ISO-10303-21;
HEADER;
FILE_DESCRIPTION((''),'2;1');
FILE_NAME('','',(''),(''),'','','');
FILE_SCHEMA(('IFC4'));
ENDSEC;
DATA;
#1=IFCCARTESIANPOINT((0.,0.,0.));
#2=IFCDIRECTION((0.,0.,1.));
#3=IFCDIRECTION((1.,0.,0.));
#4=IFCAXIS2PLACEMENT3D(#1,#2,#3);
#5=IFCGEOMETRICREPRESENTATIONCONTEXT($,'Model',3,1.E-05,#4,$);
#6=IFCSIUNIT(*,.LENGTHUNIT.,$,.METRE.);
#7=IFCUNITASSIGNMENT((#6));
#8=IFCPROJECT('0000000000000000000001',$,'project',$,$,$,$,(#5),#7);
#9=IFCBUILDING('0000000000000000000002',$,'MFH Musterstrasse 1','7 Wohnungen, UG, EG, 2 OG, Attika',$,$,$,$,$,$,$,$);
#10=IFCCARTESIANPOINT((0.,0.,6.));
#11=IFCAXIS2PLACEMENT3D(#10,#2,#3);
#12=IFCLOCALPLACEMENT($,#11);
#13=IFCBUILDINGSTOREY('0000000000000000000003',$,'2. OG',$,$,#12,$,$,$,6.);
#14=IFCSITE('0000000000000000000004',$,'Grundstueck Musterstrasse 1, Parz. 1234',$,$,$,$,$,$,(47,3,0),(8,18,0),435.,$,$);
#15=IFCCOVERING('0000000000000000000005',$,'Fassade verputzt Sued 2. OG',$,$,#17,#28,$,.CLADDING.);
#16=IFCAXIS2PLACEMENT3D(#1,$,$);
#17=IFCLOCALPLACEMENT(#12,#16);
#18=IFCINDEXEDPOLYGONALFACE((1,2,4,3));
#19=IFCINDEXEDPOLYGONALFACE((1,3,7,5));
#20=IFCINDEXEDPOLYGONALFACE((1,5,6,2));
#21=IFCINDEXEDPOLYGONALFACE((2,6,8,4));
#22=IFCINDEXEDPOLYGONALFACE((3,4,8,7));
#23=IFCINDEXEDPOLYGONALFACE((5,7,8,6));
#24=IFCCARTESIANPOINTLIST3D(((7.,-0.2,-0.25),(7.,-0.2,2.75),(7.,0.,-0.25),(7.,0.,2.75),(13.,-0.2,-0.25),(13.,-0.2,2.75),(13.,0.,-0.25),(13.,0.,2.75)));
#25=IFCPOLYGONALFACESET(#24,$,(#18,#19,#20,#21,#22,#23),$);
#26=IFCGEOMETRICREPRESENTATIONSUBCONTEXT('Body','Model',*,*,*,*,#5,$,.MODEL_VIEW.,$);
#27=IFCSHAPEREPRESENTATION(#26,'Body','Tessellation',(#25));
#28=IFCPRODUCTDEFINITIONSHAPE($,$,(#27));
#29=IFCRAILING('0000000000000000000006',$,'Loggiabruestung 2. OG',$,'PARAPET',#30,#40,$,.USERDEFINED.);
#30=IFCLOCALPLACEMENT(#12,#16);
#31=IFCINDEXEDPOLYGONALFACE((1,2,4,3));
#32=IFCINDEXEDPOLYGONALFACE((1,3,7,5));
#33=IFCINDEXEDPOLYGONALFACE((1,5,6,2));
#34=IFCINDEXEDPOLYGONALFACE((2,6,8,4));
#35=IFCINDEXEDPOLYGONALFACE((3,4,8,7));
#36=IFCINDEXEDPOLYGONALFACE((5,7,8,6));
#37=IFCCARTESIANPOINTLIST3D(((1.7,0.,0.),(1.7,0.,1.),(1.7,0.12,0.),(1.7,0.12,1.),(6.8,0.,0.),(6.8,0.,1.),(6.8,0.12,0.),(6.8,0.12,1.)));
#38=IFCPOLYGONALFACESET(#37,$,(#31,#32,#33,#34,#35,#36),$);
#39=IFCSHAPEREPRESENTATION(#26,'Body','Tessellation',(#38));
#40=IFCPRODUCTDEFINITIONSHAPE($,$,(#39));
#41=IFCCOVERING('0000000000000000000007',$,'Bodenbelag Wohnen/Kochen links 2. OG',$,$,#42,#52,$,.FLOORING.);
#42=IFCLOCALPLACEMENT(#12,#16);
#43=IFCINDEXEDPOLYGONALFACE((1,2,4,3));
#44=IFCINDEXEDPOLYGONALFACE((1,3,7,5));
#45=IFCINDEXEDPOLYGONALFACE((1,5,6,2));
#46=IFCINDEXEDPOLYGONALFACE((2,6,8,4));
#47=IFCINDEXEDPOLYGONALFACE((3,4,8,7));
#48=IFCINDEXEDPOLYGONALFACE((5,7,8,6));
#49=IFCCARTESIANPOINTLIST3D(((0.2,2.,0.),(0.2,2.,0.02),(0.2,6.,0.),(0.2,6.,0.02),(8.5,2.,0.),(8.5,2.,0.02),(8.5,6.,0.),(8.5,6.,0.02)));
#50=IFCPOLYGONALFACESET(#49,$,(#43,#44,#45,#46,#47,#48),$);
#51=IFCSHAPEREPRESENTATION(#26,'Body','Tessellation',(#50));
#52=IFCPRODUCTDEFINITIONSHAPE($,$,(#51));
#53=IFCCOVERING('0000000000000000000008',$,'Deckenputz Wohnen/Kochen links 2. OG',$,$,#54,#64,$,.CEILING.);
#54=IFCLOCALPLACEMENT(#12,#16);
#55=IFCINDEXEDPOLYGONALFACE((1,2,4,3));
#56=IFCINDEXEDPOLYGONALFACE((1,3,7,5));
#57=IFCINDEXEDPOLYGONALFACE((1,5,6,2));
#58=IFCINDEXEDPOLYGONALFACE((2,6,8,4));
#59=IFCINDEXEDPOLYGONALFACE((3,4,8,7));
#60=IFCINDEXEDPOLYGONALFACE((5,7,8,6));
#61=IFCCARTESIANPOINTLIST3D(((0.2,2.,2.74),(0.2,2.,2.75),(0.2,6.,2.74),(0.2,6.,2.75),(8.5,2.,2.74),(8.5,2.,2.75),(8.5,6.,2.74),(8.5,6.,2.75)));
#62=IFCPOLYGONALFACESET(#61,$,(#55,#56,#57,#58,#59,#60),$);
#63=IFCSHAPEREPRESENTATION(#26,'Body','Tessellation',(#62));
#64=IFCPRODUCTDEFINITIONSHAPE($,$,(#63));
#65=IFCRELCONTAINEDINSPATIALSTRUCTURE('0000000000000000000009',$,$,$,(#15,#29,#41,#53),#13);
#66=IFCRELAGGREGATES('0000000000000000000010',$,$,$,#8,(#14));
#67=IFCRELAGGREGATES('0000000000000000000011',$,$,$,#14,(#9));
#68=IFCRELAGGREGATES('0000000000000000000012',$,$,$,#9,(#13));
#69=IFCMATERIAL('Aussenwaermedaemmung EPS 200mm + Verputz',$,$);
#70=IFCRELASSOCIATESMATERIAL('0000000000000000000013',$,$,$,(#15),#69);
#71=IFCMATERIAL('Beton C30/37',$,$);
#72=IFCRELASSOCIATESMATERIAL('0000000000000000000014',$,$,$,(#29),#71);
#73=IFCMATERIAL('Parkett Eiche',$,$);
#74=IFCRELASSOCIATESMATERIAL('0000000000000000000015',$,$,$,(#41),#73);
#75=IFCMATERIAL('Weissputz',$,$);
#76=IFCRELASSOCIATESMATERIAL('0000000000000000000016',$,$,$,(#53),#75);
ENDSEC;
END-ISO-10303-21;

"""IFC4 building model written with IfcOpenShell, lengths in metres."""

from ifc_helpers import new_model, si_unit, frame, frame_2d, origin_with_axes, place, context, subcontext, project, spatial, rectangle, extrude, material, element, save


model = new_model("IFC4")

# Units and contexts
model_context = context("Model", 3, precision=1e-05, world=origin_with_axes())
body_context = subcontext(model_context, "Body", "Model", "MODEL_VIEW")
ifc_project = project(units=[si_unit("LENGTHUNIT", "METRE")], contexts=[model_context])

# Site, building, storey
site = spatial("IfcSite", under=ifc_project, Name="Grundstueck Musterstrasse 1, Parz. 1234", RefLatitude=(47, 3, 0), RefLongitude=(8, 18, 0), RefElevation=435.0)
building = spatial("IfcBuilding", under=site, Name="MFH Musterstrasse 1", Description="7 Wohnungen, UG, EG, 2 OG, Attika")
storey_placement = place(None, frame((0.0, 0.0, 6.0), z_axis=(0.0, 0.0, 1.0), x_axis=(1.0, 0.0, 0.0)))
storey = spatial("IfcBuildingStorey", under=building, at=storey_placement, Name="2. OG", Elevation=6.0)

# Shared definitions
ifc_material_1 = material(Name="Aussenwaermedaemmung EPS 200mm + Verputz")

# Covering
covering_1_placement = place(storey_placement, frame((7.0, -0.2, -0.25), z_axis=(0.0, 0.0, 1.0), x_axis=(1.0, 0.0, 0.0)))
element("IfcCovering", 1, at=covering_1_placement, inside=storey, material=ifc_material_1, Name="Fassade verputzt Sued 2. OG", PredefinedType="CLADDING", context=body_context, shape_type="SweptSolid", body=[
    extrude(rectangle(XDim=6.0, YDim=0.2, at=frame_2d((3.0, 0.1))), origin_with_axes(), (0.0, 0.0, 1.0), 3.0),
])

# Railing
ifc_material_2 = material(Name="Beton C30/37")
railing_placement = place(storey_placement, frame((1.7, 0.0, 0.0), z_axis=(0.0, 0.0, 1.0), x_axis=(1.0, 0.0, 0.0)))
element("IfcRailing", 2, at=railing_placement, inside=storey, material=ifc_material_2, Name="Loggiabruestung 2. OG", ObjectType="PARAPET", PredefinedType="USERDEFINED", context=body_context, shape_type="SweptSolid", body=[
    extrude(rectangle(XDim=5.1, YDim=0.12, at=frame_2d((2.55, 0.06))), origin_with_axes(), (0.0, 0.0, 1.0), 1.0),
])

# Coverings
ifc_material_3 = material(Name="Parkett Eiche")
covering_2_placement = place(storey_placement, frame((0.2, 2.0, 0.0), z_axis=(0.0, 0.0, 1.0), x_axis=(1.0, 0.0, 0.0)))
element("IfcCovering", 3, at=covering_2_placement, inside=storey, material=ifc_material_3, Name="Bodenbelag Wohnen/Kochen links 2. OG", PredefinedType="FLOORING", context=body_context, shape_type="SweptSolid", body=[
    extrude(rectangle(XDim=8.3, YDim=4.0, at=frame_2d((4.15, 2.0))), origin_with_axes(), (0.0, 0.0, 1.0), 0.02),
])
ifc_material_4 = material(Name="Weissputz")
covering_3_placement = place(storey_placement, frame((0.2, 2.0, 2.74), z_axis=(0.0, 0.0, 1.0), x_axis=(1.0, 0.0, 0.0)))
element("IfcCovering", 4, at=covering_3_placement, inside=storey, material=ifc_material_4, Name="Deckenputz Wohnen/Kochen links 2. OG", PredefinedType="CEILING", context=body_context, shape_type="SweptSolid", body=[
    extrude(rectangle(XDim=8.3, YDim=4.0, at=frame_2d((4.15, 2.0))), origin_with_axes(), (0.0, 0.0, 1.0), 0.01),
])

save(model, "model.ifc")
